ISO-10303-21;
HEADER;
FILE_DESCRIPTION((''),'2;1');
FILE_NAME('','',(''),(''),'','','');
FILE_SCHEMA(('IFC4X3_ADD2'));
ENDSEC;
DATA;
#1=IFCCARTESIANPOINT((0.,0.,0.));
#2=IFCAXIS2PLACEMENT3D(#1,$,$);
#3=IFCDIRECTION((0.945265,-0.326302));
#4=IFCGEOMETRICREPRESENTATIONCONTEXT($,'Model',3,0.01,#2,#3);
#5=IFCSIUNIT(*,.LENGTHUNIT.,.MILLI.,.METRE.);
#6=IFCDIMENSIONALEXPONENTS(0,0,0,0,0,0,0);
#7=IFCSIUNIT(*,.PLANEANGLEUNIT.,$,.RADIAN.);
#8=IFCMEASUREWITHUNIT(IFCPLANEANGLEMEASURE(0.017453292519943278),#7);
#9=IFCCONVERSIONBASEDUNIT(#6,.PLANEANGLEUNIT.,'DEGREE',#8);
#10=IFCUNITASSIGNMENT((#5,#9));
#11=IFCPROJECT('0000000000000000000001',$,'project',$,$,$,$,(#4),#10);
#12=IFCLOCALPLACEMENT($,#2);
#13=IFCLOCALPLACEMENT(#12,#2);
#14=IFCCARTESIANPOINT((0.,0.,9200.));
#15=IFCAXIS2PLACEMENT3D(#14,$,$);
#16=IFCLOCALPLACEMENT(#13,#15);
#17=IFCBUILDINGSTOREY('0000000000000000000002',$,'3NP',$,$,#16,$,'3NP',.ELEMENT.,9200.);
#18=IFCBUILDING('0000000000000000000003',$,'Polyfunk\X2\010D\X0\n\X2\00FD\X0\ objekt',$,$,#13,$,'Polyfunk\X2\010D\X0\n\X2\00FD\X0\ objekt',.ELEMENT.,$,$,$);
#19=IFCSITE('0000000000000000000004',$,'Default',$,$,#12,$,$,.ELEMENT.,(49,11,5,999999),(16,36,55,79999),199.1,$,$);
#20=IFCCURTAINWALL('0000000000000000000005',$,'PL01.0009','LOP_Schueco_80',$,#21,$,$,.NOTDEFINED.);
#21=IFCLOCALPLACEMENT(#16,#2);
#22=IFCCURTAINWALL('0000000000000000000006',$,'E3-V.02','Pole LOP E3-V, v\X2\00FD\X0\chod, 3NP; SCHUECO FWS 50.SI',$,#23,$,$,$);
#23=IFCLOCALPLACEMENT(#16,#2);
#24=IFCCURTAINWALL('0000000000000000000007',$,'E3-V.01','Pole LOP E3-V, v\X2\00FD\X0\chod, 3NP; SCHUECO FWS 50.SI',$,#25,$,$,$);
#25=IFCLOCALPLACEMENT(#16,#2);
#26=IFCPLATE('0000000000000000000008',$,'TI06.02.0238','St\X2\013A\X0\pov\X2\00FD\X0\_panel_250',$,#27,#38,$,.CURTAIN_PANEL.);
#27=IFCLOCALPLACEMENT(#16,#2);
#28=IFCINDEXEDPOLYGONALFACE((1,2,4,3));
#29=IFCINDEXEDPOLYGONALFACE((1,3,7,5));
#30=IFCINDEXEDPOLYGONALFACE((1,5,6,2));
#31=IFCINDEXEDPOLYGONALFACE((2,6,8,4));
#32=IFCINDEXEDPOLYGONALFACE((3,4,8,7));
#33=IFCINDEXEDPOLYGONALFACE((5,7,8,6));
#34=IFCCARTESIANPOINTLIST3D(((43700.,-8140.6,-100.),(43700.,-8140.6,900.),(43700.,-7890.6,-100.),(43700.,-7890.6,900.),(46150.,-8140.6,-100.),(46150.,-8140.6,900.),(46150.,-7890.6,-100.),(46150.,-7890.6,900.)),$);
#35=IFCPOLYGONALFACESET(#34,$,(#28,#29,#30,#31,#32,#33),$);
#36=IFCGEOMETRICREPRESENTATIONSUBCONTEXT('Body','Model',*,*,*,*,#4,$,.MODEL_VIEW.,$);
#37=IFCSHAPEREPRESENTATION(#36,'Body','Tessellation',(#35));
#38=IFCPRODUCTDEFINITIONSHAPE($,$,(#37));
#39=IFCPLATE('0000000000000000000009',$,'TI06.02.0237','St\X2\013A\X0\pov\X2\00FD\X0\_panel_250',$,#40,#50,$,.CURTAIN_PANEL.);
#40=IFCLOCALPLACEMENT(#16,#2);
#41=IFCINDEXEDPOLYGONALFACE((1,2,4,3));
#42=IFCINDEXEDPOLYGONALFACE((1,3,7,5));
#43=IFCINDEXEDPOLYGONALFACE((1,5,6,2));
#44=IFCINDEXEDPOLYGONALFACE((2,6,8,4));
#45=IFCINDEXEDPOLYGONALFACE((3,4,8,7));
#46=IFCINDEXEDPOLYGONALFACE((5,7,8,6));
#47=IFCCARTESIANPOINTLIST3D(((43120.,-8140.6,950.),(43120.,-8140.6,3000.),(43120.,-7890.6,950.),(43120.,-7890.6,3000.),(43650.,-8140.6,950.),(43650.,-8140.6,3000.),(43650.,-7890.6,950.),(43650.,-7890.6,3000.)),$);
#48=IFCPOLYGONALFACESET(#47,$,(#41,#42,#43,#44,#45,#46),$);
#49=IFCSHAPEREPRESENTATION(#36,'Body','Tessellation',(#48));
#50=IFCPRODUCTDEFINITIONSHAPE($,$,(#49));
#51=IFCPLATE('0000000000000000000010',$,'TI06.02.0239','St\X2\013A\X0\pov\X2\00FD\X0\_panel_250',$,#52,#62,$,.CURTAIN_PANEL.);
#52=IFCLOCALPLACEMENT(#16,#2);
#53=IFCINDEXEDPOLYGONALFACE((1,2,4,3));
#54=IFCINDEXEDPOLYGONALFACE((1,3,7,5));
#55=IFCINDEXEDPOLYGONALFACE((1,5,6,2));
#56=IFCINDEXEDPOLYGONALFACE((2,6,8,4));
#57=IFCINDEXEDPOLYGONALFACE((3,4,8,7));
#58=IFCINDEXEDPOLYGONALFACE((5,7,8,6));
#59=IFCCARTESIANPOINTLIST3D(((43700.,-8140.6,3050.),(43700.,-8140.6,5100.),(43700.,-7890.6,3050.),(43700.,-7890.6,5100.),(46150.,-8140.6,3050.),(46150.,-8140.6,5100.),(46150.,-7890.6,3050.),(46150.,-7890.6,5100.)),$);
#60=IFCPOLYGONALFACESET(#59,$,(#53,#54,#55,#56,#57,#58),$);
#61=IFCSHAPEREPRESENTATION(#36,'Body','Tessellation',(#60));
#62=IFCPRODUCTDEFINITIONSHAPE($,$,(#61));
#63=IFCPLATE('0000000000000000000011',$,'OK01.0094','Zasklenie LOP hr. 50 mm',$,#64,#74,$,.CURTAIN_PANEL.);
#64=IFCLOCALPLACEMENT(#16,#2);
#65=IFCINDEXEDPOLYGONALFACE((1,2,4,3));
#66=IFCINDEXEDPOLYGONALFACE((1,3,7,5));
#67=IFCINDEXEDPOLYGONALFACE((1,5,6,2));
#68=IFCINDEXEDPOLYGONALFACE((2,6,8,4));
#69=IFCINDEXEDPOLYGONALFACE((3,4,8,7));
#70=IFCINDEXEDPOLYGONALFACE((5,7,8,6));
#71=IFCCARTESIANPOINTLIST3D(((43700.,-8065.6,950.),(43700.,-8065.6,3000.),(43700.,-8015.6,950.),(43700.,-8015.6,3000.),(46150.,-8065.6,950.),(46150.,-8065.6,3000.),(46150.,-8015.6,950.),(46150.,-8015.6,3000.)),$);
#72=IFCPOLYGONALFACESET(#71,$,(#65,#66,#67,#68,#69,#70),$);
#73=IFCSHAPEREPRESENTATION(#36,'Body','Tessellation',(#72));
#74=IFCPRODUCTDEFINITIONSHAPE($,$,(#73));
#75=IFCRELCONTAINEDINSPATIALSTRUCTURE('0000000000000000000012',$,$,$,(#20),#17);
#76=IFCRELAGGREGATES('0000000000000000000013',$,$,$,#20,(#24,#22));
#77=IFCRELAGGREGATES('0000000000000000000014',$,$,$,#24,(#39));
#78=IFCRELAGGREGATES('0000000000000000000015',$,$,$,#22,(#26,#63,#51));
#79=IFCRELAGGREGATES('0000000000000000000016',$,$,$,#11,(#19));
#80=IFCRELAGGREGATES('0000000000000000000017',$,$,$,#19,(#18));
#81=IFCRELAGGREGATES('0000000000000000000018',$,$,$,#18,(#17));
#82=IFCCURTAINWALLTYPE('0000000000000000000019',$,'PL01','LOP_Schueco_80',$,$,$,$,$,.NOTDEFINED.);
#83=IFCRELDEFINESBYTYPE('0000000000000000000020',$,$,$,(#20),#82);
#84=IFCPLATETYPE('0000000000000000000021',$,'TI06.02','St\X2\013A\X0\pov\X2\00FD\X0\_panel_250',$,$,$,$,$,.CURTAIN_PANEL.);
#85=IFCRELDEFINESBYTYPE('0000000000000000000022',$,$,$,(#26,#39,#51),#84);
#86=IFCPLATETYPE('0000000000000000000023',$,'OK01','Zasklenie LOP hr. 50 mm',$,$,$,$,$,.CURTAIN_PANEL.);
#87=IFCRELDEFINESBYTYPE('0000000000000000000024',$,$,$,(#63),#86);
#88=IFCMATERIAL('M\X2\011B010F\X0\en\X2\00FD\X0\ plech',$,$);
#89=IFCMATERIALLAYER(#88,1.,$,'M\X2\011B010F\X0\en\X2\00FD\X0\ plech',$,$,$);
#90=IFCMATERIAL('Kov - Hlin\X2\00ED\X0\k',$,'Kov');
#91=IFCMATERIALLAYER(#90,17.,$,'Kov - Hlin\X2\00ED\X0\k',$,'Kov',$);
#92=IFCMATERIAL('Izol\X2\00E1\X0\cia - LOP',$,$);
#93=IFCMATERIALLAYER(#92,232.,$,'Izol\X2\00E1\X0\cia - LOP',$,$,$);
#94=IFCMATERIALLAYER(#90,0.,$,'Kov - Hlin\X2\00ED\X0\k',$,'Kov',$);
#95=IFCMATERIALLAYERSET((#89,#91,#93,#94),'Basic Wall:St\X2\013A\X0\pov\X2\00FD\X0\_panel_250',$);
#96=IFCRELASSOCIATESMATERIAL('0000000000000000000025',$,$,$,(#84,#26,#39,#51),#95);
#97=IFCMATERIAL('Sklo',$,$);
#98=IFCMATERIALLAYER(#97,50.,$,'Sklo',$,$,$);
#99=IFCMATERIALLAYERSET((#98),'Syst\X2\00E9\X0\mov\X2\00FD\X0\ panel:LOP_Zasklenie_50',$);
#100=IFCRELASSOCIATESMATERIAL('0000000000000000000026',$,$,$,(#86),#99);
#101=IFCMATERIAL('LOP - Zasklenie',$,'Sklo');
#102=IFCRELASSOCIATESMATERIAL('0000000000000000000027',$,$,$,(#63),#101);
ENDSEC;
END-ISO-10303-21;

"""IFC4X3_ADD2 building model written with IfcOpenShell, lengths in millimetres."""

from ifc_helpers import new_model, entity, si_unit, converted_unit, direction, frame, frame_2d, origin, origin_2d_with_axis, place, context, subcontext, project, spatial, rectangle, extrude, source, transform, mapped, material, layer, layer_set, layer_usage, type_object, type_shapes, element, aggregate, save


model = new_model("IFC4X3_ADD2")

# Units and contexts
model_context = context("Model", 3, precision=0.01, world=origin(), true_north=direction((0.945265, -0.326302)))
body_context = subcontext(model_context, "Body", "Model", "MODEL_VIEW")
ifc_project = project(units=[si_unit("LENGTHUNIT", "METRE", prefix="MILLI"), converted_unit("PLANEANGLEUNIT", "DEGREE", entity("IfcPlaneAngleMeasure", 0.017453292519943278), si_unit("PLANEANGLEUNIT", "RADIAN"), dimensions=[0, 0, 0, 0, 0, 0, 0])], contexts=[model_context])

# Site, building, storey
site_placement = place(None, origin())
site = spatial("IfcSite", under=ifc_project, at=site_placement, Name="Default", CompositionType="ELEMENT", RefLatitude=(49, 11, 5, 999999), RefLongitude=(16, 36, 55, 79999), RefElevation=199.1)
building_placement = place(site_placement, origin())
building = spatial("IfcBuilding", under=site, at=building_placement, Name="Polyfunkčný objekt", LongName="Polyfunkčný objekt", CompositionType="ELEMENT")
storey_placement = place(building_placement, frame((0.0, 0.0, 9200.0)))
storey = spatial("IfcBuildingStorey", under=building, at=storey_placement, Name="3NP", LongName="3NP", CompositionType="ELEMENT", Elevation=9200.0)

# Curtain walls, plates
curtain_wall_type = type_object("IfcCurtainWallType", Name="PL01", Description="LOP_Schueco_80", PredefinedType="NOTDEFINED")
curtain_wall_1_placement = place(storey_placement, frame((0.0, 0.0, -9200.0)))
curtain_wall_1 = element("IfcCurtainWall", 1, at=curtain_wall_1_placement, inside=storey, type_object=curtain_wall_type, Name="PL01.0009", Description="LOP_Schueco_80", PredefinedType="NOTDEFINED")
curtain_wall_2 = element("IfcCurtainWall", 2, Name="E3-V.02", Description="Pole LOP E3-V, východ, 3NP; SCHUECO FWS 50.SI")
curtain_wall_3 = element("IfcCurtainWall", 3, Name="E3-V.01", Description="Pole LOP E3-V, východ, 3NP; SCHUECO FWS 50.SI")
aggregate(curtain_wall_1, [curtain_wall_3, curtain_wall_2])
ifc_material_1 = material(Name="Měďený plech")
ifc_layer_1 = layer(ifc_material_1, 1.0, Name="Měďený plech")
ifc_material_2 = material(Name="Kov - Hliník", Category="Kov")
ifc_layer_2 = layer(ifc_material_2, 17.0, Name="Kov - Hliník", Category="Kov")
ifc_material_3 = material(Name="Izolácia - LOP")
ifc_layer_3 = layer(ifc_material_3, 232.0, Name="Izolácia - LOP")
ifc_layer_4 = layer(ifc_material_2, 0.0, Name="Kov - Hliník", Category="Kov")
ifc_layer_set_1 = layer_set([ifc_layer_1, ifc_layer_2, ifc_layer_3, ifc_layer_4], Name="Basic Wall:Stĺpový_panel_250")
ifc_layer_usage_1 = layer_usage(ifc_layer_set_1, "AXIS2", "POSITIVE", -125.0)
plate_type_1 = type_object("IfcPlateType", Name="TI06.02", Description="Stĺpový_panel_250", PredefinedType="CURTAIN_PANEL", material=ifc_layer_set_1)
plate_1_placement = place(storey_placement, frame((43700.0, -8015.6, -100.0)))
plate_1 = element("IfcPlate", 4, at=plate_1_placement, type_object=plate_type_1, material=ifc_layer_usage_1, Name="TI06.02.0238", Description="Stĺpový_panel_250", PredefinedType="CURTAIN_PANEL", context=body_context, shape_type="SweptSolid", body=[
    extrude(rectangle(XDim=250.0, YDim=2450.0, at=frame_2d((0.0, 0.0), x_axis=(1.0, 0.0))), frame((1225.0, 0.0, 0.0), z_axis=(0.0, 0.0, 1.0), x_axis=(0.0, 1.0, 0.0)), (0.0, 0.0, 1.0), 1000.0),
])
ifc_layer_usage_2 = layer_usage(ifc_layer_set_1, "AXIS2", "POSITIVE", -125.0)
plate_2_placement = place(storey_placement, frame((43120.0, -8015.6, 950.0)))
plate_2 = element("IfcPlate", 5, at=plate_2_placement, type_object=plate_type_1, material=ifc_layer_usage_2, Name="TI06.02.0237", Description="Stĺpový_panel_250", PredefinedType="CURTAIN_PANEL", context=body_context, shape_type="SweptSolid", body=[
    extrude(rectangle(XDim=250.0, YDim=530.0, at=frame_2d((0.0, 0.0), x_axis=(1.0, 0.0))), frame((265.0, 0.0, 0.0), z_axis=(0.0, 0.0, 1.0), x_axis=(0.0, 1.0, 0.0)), (0.0, 0.0, 1.0), 2050.0),
])
aggregate(curtain_wall_3, [plate_2])
ifc_layer_usage_3 = layer_usage(ifc_layer_set_1, "AXIS2", "POSITIVE", -125.0)
plate_3_placement = place(storey_placement, frame((43700.0, -8015.6, 3050.0)))
plate_3 = element("IfcPlate", 6, at=plate_3_placement, type_object=plate_type_1, material=ifc_layer_usage_3, Name="TI06.02.0239", Description="Stĺpový_panel_250", PredefinedType="CURTAIN_PANEL", context=body_context, shape_type="SweptSolid", body=[
    extrude(rectangle(XDim=250.0, YDim=2450.0, at=frame_2d((0.0, 0.0), x_axis=(1.0, 0.0))), frame((1225.0, 0.0, 0.0), z_axis=(0.0, 0.0, 1.0), x_axis=(0.0, 1.0, 0.0)), (0.0, 0.0, 1.0), 2050.0),
])
ifc_material_4 = material(Name="LOP - Zasklenie", Category="Sklo")
ifc_material_5 = material(Name="Sklo")
ifc_layer_5 = layer(ifc_material_5, 50.0, Name="Sklo")
ifc_layer_set_2 = layer_set([ifc_layer_5], Name="Systémový panel:LOP_Zasklenie_50")
plate_type_2 = type_object("IfcPlateType", Name="OK01", Description="Zasklenie LOP hr. 50 mm", PredefinedType="CURTAIN_PANEL", material=ifc_layer_set_2)
shared_shape_1 = source(origin(), body_context, "Body", "SweptSolid", [
    extrude(rectangle(XDim=50.0, YDim=2450.0, at=origin_2d_with_axis()), frame((0.0, -25.0, 0.0), z_axis=(0.0, 0.0, 1.0), x_axis=(0.0, 1.0, 0.0)), (0.0, 0.0, 1.0), 2050.0),
])
type_shapes(plate_type_2, [shared_shape_1])
plate_4_placement = place(curtain_wall_1_placement, frame((44925.0, -8015.6, 10150.0)))
plate_4 = element("IfcPlate", 7, at=plate_4_placement, type_object=plate_type_2, material=ifc_material_4, Name="OK01.0094", Description="Zasklenie LOP hr. 50 mm", PredefinedType="CURTAIN_PANEL", context=body_context, shape_type="MappedRepresentation", body=[
    mapped(shared_shape_1, transform((0.0, 0.0, 0.0), scale=1.0)),
])
aggregate(curtain_wall_2, [plate_1, plate_4, plate_3])

save(model, "model.ifc")
